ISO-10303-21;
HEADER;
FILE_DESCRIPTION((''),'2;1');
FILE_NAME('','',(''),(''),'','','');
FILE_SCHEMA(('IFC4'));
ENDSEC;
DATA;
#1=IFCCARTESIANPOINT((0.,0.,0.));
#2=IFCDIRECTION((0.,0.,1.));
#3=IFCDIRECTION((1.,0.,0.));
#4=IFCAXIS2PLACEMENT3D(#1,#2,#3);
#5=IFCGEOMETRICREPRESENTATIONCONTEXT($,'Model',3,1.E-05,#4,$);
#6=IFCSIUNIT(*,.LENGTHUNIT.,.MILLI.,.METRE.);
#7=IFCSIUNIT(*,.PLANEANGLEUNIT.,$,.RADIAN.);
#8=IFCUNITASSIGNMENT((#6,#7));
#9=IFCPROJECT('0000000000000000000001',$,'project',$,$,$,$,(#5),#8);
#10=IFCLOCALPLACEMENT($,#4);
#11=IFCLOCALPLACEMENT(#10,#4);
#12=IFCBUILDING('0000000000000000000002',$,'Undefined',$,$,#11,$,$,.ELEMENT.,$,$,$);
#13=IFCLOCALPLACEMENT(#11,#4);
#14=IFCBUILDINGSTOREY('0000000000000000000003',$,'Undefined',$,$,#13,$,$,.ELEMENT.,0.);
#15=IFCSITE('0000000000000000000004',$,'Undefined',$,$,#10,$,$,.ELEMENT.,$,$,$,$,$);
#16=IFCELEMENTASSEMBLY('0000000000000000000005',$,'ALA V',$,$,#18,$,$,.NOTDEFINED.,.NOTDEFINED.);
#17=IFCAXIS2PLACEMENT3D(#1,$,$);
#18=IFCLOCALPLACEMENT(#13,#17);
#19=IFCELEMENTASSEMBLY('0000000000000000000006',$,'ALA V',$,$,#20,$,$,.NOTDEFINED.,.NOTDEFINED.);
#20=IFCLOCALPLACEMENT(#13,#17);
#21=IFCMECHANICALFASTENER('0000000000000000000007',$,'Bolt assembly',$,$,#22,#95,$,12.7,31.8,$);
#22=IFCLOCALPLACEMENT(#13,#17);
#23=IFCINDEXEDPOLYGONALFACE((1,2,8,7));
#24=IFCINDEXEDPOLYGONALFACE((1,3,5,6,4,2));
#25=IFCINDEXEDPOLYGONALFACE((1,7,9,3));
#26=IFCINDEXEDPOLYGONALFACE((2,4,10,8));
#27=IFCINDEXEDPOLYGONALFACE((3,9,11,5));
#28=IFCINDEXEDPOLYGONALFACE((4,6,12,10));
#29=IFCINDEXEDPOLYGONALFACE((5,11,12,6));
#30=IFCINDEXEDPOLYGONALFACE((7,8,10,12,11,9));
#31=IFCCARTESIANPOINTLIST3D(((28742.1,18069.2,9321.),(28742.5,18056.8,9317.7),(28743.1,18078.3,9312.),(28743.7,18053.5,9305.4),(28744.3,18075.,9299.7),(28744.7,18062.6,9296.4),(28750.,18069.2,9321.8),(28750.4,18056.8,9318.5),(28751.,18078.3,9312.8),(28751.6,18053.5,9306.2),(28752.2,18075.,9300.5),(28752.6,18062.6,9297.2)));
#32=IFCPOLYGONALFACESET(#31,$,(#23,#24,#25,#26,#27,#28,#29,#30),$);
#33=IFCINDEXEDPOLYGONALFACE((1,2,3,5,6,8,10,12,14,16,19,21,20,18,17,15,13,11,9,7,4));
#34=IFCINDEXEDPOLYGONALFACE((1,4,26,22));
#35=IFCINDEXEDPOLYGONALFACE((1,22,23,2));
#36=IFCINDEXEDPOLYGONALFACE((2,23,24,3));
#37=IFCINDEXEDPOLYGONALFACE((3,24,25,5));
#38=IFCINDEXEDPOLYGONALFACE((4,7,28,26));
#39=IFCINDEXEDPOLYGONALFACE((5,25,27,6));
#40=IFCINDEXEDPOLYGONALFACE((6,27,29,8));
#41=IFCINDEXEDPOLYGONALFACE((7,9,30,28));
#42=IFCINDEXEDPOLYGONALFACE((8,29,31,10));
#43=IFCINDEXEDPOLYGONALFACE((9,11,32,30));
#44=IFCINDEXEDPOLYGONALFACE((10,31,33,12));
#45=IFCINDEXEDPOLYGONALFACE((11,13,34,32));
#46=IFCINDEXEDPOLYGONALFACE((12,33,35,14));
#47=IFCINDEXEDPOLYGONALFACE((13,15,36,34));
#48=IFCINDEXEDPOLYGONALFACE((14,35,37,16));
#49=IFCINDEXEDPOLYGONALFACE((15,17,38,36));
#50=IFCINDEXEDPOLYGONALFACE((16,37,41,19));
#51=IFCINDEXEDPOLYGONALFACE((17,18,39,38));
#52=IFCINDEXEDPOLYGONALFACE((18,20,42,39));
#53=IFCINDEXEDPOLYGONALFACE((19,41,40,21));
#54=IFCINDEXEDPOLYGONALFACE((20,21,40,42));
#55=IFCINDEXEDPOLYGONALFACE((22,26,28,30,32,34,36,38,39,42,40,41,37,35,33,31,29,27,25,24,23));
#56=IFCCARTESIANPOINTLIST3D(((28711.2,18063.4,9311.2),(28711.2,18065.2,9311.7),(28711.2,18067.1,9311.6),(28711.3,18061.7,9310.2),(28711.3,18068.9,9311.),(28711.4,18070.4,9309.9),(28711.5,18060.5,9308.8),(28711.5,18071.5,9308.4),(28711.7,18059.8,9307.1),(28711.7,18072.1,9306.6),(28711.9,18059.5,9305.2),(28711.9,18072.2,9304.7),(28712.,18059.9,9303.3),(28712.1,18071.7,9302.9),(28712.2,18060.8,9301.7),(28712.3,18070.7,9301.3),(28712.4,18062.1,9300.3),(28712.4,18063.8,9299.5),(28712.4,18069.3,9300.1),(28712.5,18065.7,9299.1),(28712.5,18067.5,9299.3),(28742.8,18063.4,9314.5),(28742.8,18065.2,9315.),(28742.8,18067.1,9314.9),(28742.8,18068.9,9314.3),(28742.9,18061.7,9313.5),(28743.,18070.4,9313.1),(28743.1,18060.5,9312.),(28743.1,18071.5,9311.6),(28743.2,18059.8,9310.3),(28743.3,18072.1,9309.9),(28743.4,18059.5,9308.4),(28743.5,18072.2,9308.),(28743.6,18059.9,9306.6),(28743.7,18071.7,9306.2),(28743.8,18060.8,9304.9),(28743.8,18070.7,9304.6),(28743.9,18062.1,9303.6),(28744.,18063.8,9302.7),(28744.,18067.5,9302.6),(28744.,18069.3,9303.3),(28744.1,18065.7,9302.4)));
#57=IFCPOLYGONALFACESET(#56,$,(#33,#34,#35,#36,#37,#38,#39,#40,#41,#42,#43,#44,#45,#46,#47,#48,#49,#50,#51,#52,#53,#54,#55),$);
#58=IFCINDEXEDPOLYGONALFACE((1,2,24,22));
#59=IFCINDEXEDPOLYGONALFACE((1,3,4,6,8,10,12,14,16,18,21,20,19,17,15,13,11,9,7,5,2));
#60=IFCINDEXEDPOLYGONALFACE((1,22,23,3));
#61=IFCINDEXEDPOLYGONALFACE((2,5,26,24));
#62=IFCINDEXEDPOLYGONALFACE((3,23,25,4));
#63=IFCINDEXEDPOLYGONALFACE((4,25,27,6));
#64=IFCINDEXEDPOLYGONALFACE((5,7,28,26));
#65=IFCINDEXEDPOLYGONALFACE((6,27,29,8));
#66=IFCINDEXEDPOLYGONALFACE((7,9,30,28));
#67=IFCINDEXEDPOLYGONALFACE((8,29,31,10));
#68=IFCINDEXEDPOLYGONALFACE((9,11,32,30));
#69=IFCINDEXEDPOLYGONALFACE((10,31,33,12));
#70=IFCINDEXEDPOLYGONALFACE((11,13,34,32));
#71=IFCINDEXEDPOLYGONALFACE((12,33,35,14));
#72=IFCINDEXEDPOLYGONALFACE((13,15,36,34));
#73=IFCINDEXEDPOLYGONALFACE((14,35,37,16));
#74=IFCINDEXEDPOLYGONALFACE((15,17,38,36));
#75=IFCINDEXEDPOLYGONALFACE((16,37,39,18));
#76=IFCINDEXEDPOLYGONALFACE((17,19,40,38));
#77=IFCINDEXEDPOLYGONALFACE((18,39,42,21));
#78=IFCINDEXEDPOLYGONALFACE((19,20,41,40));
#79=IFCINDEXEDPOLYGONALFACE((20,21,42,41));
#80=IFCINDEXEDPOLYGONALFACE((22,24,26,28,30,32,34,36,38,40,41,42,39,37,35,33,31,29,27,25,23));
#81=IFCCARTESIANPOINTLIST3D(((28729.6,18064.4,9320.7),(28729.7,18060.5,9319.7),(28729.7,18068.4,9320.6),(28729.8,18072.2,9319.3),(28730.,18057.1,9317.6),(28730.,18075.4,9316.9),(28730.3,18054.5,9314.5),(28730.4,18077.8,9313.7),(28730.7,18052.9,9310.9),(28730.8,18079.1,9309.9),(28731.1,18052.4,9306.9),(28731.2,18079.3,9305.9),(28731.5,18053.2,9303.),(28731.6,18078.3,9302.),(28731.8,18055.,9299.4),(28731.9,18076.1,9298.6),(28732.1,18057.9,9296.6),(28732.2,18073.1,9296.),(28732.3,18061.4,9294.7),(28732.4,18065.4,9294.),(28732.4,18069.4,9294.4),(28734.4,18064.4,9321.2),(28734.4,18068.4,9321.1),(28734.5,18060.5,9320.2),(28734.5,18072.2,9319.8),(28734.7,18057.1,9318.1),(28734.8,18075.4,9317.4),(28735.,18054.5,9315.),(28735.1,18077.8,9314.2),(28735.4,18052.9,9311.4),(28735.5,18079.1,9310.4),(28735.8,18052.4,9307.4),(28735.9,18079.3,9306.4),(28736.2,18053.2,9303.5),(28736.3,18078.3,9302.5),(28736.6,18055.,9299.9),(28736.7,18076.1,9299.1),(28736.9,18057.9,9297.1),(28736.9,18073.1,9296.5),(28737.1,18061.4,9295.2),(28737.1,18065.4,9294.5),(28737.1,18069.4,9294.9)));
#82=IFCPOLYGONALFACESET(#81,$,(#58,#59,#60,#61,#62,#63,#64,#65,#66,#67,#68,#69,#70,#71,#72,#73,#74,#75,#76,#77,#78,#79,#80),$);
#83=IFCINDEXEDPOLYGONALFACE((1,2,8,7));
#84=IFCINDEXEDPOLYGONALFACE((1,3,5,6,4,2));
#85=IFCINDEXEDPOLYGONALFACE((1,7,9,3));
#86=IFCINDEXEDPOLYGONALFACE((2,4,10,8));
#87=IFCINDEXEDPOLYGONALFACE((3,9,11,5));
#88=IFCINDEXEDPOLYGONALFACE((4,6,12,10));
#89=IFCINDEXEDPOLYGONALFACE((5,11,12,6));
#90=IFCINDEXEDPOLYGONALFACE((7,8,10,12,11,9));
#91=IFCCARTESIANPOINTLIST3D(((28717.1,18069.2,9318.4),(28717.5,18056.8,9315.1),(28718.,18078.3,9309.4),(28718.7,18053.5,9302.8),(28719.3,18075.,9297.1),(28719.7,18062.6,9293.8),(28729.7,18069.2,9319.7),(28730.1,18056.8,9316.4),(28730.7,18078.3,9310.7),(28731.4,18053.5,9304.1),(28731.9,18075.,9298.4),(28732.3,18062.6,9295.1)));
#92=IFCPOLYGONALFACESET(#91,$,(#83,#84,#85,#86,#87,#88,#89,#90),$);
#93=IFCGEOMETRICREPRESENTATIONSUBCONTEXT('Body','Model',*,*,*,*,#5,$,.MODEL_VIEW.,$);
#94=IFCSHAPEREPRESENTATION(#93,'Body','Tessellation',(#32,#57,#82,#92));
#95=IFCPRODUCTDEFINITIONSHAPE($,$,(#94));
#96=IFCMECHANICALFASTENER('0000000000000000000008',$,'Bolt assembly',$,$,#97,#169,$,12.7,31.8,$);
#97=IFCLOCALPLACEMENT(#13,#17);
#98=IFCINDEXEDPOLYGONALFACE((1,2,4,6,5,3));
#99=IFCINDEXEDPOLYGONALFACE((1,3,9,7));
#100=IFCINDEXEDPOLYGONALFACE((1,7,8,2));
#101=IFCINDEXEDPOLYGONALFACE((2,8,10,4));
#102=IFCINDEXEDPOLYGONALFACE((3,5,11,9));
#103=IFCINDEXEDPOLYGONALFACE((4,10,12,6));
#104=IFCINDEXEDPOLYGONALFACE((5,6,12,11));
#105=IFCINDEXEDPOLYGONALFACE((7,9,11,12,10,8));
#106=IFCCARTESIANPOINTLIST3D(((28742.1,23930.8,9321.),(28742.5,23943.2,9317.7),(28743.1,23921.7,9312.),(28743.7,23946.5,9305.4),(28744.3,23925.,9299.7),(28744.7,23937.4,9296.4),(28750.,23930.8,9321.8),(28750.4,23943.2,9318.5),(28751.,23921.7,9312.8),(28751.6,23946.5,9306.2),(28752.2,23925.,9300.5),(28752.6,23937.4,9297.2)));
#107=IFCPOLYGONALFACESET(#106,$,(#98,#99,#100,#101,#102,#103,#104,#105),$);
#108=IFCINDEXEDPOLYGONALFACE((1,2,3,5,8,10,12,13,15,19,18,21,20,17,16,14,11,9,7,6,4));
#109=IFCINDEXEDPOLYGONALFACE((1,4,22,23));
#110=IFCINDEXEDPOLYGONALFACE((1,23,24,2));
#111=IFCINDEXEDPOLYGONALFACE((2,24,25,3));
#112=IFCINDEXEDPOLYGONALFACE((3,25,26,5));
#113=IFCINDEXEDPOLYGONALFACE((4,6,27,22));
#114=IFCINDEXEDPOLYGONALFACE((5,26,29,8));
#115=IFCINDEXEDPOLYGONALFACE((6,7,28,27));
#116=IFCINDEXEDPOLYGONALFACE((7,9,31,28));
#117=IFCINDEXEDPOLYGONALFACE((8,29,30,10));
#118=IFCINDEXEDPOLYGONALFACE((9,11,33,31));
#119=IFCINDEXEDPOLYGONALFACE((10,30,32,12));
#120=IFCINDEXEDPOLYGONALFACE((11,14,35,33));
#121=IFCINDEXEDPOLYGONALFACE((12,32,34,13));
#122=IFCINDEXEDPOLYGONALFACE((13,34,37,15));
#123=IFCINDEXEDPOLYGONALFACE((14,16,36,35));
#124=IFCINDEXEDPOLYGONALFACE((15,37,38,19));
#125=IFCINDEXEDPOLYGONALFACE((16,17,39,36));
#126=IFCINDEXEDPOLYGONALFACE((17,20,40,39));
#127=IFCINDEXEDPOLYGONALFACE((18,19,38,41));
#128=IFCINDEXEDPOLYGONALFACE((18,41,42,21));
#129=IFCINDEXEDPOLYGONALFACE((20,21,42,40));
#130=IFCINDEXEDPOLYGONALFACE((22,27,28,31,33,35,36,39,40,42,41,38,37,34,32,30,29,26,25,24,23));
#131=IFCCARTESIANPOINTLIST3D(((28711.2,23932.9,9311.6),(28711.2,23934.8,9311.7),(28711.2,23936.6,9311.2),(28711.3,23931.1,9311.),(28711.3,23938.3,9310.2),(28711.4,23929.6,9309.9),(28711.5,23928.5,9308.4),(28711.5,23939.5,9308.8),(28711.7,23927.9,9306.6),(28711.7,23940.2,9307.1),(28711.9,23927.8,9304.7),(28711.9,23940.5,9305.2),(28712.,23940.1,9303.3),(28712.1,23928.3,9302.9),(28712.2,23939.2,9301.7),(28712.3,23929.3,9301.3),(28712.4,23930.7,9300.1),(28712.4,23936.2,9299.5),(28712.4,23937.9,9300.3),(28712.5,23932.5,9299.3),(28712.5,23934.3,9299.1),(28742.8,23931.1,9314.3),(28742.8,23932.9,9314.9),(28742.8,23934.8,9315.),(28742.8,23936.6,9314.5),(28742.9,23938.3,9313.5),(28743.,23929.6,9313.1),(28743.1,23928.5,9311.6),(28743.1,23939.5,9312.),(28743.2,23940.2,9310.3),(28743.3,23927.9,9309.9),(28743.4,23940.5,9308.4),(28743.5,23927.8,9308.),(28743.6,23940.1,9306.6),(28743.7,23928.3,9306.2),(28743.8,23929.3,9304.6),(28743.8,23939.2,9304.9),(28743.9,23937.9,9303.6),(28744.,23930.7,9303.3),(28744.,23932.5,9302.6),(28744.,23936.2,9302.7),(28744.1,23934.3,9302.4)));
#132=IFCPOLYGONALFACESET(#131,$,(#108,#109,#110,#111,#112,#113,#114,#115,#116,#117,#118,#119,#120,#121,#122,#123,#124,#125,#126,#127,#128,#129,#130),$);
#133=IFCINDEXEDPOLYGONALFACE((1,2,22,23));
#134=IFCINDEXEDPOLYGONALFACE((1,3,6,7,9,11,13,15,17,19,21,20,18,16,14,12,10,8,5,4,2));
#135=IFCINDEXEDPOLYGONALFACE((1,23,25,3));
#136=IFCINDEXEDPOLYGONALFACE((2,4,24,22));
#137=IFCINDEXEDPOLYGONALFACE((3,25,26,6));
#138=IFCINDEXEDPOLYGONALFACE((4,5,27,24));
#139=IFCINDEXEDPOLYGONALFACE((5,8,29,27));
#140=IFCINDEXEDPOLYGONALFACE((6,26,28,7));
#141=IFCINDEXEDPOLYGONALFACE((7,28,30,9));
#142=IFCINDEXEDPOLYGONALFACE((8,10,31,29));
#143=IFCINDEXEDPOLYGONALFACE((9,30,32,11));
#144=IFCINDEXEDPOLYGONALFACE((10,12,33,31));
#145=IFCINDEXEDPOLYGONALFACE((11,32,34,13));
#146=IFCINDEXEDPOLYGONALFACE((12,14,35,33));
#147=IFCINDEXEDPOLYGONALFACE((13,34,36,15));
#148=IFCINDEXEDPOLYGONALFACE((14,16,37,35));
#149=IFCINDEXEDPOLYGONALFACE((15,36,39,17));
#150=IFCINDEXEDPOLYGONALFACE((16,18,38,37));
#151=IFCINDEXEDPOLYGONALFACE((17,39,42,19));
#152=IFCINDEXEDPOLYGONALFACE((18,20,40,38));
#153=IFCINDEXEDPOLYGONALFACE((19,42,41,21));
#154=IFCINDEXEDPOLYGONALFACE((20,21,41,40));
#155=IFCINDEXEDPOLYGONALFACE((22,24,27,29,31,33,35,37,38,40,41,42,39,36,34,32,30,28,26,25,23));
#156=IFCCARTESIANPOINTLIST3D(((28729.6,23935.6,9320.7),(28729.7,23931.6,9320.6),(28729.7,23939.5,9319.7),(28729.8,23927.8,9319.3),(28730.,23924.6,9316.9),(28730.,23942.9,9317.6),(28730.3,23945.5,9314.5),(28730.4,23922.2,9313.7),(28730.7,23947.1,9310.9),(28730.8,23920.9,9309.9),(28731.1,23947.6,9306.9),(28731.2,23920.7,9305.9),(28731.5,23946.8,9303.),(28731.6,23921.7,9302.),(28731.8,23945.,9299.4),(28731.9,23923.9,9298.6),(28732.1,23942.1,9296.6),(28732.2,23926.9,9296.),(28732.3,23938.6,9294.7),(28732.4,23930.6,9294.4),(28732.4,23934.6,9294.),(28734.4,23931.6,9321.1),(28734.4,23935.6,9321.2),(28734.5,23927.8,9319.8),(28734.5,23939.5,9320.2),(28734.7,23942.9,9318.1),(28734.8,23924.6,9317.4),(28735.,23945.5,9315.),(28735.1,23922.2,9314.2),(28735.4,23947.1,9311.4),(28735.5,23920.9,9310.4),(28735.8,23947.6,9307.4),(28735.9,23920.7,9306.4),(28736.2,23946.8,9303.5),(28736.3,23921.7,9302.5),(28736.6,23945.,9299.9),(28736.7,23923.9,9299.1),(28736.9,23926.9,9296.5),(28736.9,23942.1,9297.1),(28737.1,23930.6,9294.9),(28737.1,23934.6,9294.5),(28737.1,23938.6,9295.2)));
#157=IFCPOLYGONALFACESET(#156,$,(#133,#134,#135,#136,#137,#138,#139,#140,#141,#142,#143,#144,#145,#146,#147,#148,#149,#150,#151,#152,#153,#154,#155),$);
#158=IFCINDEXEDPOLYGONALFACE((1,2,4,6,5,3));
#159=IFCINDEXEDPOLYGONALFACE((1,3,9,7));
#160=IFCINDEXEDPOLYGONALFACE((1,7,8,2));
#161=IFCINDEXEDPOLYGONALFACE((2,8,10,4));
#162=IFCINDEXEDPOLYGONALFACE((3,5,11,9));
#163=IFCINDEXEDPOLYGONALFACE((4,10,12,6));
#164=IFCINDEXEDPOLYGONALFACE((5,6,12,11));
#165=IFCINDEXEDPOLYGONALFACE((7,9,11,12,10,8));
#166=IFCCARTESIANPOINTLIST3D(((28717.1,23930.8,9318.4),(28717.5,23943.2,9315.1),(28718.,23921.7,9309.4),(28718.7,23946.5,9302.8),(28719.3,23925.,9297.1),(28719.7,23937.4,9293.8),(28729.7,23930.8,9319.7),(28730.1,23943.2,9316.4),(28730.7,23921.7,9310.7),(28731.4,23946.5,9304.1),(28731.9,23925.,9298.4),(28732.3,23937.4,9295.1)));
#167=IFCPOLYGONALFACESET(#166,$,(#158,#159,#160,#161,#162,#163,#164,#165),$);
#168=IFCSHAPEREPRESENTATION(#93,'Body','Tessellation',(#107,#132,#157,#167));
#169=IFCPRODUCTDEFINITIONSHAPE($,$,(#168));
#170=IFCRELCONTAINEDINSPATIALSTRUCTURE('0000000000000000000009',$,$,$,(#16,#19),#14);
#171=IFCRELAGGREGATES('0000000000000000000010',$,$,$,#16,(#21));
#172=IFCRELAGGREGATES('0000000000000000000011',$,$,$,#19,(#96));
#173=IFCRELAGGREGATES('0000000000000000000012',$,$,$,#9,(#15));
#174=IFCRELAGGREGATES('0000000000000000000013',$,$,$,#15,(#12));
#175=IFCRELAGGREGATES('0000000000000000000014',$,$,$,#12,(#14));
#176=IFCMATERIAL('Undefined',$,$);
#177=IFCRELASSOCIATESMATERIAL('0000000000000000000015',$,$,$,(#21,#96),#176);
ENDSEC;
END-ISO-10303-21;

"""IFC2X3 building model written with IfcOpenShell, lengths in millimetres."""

from ifc_helpers import new_model, si_unit, frame, origin_with_axes, origin_2d_with_axis, place, context, subcontext, project, spatial, polyline, circle, outline, extrude, source, transform, mapped, material, element, aggregate, save


model = new_model("IFC2X3")

# Units and contexts
model_context = context("Model", 3, precision=1e-05, world=origin_with_axes())
body_context = subcontext(model_context, "Body", "Model", "MODEL_VIEW")
ifc_project = project(units=[si_unit("LENGTHUNIT", "METRE", prefix="MILLI"), si_unit("PLANEANGLEUNIT", "RADIAN")], contexts=[model_context])

# Site, building, storey
site_placement = place(None, origin_with_axes())
site = spatial("IfcSite", under=ifc_project, at=site_placement, Name="Undefined", CompositionType="ELEMENT")
building_placement = place(site_placement, origin_with_axes())
building = spatial("IfcBuilding", under=site, at=building_placement, Name="Undefined", CompositionType="ELEMENT")
storey_placement = place(building_placement, origin_with_axes())
storey = spatial("IfcBuildingStorey", under=building, at=storey_placement, Name="Undefined", CompositionType="ELEMENT", Elevation=0.0)

# Element assembly
assembly_1_placement = place(storey_placement, origin_with_axes())
assembly_1 = element("IfcElementAssembly", 1, at=assembly_1_placement, inside=storey, Name="ALA V", AssemblyPlace="NOTDEFINED", PredefinedType="NOTDEFINED")

# Element assembly
assembly_2_placement = place(storey_placement, origin_with_axes())
assembly_2 = element("IfcElementAssembly", 2, at=assembly_2_placement, inside=storey, Name="ALA V", AssemblyPlace="NOTDEFINED", PredefinedType="NOTDEFINED")

# Mechanical fasteners
ifc_material_1 = material(Name="Undefined")
shared_shape_1 = source(origin_with_axes(), body_context, "Body", "SweptSolid", [
    extrude(outline(polyline([(11.1, -6.4), (11.1, 6.4), (0.0, 12.8), (-11.1, 6.4), (-11.1, -6.4), (0.0, -12.8), (11.1, -6.4)])), frame((0.0, -11.1, 0.0), z_axis=(0.0, 1.0, 0.0), x_axis=(1.0, 0.0, 0.0)), (0.0, 0.0, 1.0), 7.9),
    extrude(circle(Radius=6.3, at=origin_2d_with_axis()), frame((0.0, -3.2, 0.0), z_axis=(0.0, 1.0, 0.0), x_axis=(1.0, 0.0, 0.0)), (0.0, 0.0, 1.0), 31.8),
    extrude(circle(Radius=13.5, at=origin_2d_with_axis()), frame((0.0, 4.5, 0.0), z_axis=(0.0, 1.0, 0.0), x_axis=(1.0, 0.0, 0.0)), (0.0, 0.0, 1.0), 4.8),
    extrude(outline(polyline([(11.1, -6.4), (11.1, 6.4), (0.0, 12.8), (-11.1, 6.4), (-11.1, -6.4), (0.0, -12.8), (11.1, -6.4)])), frame((0.0, 9.3, 0.0), z_axis=(0.0, 1.0, 0.0), x_axis=(1.0, 0.0, 0.0)), (0.0, 0.0, 1.0), 12.7),
])
mechanical_fastener_1_placement = place(assembly_1_placement, frame((28740.2, 18065.9, 9308.4), z_axis=(-0.072522, -0.707107, 0.703378), x_axis=(-0.072522, 0.707107, 0.703378)))
mechanical_fastener_1 = element("IfcMechanicalFastener", 3, at=mechanical_fastener_1_placement, material=ifc_material_1, Name="Bolt assembly", NominalDiameter=12.7, NominalLength=31.8, context=body_context, shape_type="MappedRepresentation", body=[
    mapped(shared_shape_1, transform((0.0, 0.0, 0.0))),
])
aggregate(assembly_1, [mechanical_fastener_1])
mechanical_fastener_2_placement = place(assembly_2_placement, frame((28740.2, 23934.1, 9308.4), z_axis=(0.072522, -0.707107, -0.703378), x_axis=(-0.072522, -0.707107, 0.703378)))
mechanical_fastener_2 = element("IfcMechanicalFastener", 4, at=mechanical_fastener_2_placement, material=ifc_material_1, Name="Bolt assembly", NominalDiameter=12.7, NominalLength=31.8, context=body_context, shape_type="MappedRepresentation", body=[
    mapped(shared_shape_1, transform((0.0, 0.0, 0.0))),
])
aggregate(assembly_2, [mechanical_fastener_2])

save(model, "model.ifc")
